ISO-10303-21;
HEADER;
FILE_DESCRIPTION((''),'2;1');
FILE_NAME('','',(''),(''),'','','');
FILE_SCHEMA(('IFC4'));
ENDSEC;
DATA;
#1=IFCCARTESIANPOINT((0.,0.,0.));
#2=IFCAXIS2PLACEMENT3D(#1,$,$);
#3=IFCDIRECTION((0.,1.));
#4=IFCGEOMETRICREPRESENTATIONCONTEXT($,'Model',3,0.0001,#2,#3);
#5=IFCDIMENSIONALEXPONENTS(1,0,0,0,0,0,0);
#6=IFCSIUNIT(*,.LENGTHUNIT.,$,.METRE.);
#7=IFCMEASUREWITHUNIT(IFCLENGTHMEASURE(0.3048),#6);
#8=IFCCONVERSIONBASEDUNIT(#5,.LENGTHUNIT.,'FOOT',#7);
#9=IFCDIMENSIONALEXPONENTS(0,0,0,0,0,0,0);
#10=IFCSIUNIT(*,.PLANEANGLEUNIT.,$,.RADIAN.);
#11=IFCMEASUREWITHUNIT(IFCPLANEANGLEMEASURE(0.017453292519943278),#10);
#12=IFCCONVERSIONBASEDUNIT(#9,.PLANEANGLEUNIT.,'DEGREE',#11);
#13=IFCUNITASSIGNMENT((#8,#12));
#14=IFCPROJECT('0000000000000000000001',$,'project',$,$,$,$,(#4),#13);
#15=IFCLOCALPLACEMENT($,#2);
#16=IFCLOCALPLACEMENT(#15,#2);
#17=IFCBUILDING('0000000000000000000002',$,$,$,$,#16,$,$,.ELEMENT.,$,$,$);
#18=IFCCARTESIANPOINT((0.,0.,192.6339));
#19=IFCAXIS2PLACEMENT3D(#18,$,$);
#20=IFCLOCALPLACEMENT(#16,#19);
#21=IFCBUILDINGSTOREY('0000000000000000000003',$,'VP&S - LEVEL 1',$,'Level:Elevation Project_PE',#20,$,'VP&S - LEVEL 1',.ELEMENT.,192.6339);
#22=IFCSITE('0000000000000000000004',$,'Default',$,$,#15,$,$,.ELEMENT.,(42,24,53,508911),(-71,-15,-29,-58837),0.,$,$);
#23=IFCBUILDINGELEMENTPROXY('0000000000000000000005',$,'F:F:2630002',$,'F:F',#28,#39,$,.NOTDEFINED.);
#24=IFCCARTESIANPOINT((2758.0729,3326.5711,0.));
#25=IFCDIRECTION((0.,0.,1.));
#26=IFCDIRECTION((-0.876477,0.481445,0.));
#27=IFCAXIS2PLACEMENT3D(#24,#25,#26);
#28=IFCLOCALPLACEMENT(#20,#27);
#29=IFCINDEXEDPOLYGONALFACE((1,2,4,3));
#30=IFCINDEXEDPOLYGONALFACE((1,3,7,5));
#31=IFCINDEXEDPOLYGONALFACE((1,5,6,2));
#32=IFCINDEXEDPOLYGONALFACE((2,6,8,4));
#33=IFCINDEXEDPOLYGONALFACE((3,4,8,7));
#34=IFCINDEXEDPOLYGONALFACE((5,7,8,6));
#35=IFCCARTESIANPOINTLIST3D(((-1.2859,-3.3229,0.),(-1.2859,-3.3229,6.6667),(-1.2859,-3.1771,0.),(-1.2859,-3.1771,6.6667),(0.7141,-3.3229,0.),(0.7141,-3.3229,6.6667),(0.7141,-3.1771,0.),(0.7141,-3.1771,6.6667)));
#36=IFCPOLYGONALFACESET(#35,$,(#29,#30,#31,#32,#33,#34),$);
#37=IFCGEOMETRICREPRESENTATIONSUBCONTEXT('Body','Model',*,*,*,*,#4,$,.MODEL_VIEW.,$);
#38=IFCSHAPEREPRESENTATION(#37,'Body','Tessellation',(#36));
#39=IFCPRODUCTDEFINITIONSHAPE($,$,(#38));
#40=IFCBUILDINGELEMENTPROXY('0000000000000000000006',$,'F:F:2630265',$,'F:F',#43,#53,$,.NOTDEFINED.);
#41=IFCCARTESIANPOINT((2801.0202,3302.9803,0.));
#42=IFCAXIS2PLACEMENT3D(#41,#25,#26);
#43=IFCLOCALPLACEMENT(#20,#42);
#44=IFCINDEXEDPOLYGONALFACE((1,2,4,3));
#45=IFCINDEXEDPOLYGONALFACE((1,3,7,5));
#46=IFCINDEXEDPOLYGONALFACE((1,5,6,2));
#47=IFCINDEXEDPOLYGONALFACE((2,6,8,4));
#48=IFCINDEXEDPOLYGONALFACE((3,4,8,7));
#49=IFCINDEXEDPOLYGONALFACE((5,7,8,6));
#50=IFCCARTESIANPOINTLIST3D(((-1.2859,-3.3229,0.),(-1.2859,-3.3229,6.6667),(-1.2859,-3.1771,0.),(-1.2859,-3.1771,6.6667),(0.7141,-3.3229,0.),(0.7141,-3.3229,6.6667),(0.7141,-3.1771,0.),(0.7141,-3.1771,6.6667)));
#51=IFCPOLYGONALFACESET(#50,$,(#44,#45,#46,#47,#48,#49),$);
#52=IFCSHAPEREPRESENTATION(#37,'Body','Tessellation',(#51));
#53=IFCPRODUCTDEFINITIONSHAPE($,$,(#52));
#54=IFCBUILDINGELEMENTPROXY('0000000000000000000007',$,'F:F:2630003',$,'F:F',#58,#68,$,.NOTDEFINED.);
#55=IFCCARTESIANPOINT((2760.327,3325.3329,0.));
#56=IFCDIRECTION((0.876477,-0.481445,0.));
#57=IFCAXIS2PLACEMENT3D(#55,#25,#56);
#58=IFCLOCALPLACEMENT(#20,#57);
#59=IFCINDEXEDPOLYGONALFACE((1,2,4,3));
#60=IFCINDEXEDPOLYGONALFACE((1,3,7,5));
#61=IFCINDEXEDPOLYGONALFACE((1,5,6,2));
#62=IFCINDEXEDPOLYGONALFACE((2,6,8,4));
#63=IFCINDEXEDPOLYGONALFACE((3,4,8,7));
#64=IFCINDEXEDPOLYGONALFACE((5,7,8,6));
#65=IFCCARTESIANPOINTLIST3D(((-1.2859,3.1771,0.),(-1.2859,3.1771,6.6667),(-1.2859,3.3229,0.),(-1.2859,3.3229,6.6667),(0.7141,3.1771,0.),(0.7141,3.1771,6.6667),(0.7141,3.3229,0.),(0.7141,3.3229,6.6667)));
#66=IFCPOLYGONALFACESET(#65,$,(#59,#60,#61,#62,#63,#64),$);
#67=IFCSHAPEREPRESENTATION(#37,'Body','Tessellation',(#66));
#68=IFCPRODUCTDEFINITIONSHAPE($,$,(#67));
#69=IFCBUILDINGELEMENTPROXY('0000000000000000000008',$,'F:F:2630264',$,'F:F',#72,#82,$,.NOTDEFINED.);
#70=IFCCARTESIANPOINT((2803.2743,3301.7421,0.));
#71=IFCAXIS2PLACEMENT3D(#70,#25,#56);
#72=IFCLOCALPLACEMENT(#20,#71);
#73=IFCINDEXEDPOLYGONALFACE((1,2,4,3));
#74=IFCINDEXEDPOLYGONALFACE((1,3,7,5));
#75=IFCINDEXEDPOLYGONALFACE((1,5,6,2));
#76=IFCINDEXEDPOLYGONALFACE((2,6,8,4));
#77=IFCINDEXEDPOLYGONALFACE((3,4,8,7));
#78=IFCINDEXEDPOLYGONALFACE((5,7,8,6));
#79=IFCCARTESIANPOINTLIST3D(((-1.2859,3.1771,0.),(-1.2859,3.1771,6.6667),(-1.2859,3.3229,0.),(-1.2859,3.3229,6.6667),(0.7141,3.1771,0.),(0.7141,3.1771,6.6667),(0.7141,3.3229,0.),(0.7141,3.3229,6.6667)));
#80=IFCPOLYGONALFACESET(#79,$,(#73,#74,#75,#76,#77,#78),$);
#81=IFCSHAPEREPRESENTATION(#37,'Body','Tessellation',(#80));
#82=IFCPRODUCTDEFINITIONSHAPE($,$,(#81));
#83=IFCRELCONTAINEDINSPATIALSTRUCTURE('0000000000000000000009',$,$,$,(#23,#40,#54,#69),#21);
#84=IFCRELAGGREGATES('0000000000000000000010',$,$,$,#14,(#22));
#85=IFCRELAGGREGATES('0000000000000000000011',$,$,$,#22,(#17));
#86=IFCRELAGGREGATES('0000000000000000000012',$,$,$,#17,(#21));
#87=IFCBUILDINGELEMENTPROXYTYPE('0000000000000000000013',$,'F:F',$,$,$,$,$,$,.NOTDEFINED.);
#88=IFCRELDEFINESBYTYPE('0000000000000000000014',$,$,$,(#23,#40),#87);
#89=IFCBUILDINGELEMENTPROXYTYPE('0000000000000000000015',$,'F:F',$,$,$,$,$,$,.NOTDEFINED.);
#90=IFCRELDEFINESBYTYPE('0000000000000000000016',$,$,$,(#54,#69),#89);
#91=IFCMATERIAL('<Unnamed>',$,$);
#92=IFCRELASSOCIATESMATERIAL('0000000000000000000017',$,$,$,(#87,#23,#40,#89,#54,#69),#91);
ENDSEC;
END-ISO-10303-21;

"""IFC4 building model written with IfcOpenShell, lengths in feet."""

from ifc_helpers import new_model, entity, si_unit, converted_unit, direction, frame, origin, place, context, subcontext, project, spatial, indexed_curve, outline, extrude, source, transform, mapped, material, type_object, type_shapes, element, save


model = new_model("IFC4")

# Units and contexts
model_context = context("Model", 3, precision=0.0001, world=origin(), true_north=direction((0.0, 1.0)))
body_context = subcontext(model_context, "Body", "Model", "MODEL_VIEW")
ifc_project = project(units=[converted_unit("LENGTHUNIT", "FOOT", entity("IfcLengthMeasure", 0.3048), si_unit("LENGTHUNIT", "METRE"), dimensions=[1, 0, 0, 0, 0, 0, 0]), converted_unit("PLANEANGLEUNIT", "DEGREE", entity("IfcPlaneAngleMeasure", 0.017453292519943278), si_unit("PLANEANGLEUNIT", "RADIAN"), dimensions=[0, 0, 0, 0, 0, 0, 0])], contexts=[model_context])

# Site, building, storey
site_placement = place(None, origin())
site = spatial("IfcSite", under=ifc_project, at=site_placement, Name="Default", CompositionType="ELEMENT", RefLatitude=(42, 24, 53, 508911), RefLongitude=(-71, -15, -29, -58837), RefElevation=0.0)
building_placement = place(site_placement, origin())
building = spatial("IfcBuilding", under=site, at=building_placement, CompositionType="ELEMENT")
storey_placement = place(building_placement, frame((0.0, 0.0, 192.6339)))
storey = spatial("IfcBuildingStorey", under=building, at=storey_placement, Name="VP&S - LEVEL 1", ObjectType="Level:Elevation Project_PE", LongName="VP&S - LEVEL 1", CompositionType="ELEMENT", Elevation=192.6339)

# Shared definitions
ifc_material = material(Name="<Unnamed>")

# Building element proxies
building_element_proxy_type_1 = type_object("IfcBuildingElementProxyType", Name="F:F", PredefinedType="NOTDEFINED", material=ifc_material)
shared_shape_1 = source(origin(), body_context, "Body", "SweptSolid", [
    extrude(outline(indexed_curve([(-1.0, -0.0729), (1.0, -0.0729), (1.0, 0.0729), (-1.0, 0.0729), (-1.0, -0.0729)], self_intersect=False)), frame((-0.2859, -3.25, 0.0), z_axis=(0.0, 0.0, 1.0), x_axis=(-1.0, 0.0, 0.0)), (0.0, 0.0, 1.0), 6.6667),
])
type_shapes(building_element_proxy_type_1, [shared_shape_1])
for number, where, z_axis, x_axis, name in (
    (1, (2758.0729, 3326.5711, 0.0), (0.0, 0.0, 1.0), (-0.876477, 0.481445, 0.0), "F:F:2630002"),
    (2, (2801.0202, 3302.9803, 0.0), (0.0, 0.0, 1.0), (-0.876477, 0.481445, 0.0), "F:F:2630265"),
):
    element("IfcBuildingElementProxy", number, at=place(storey_placement, frame(where, z_axis=z_axis, x_axis=x_axis)), inside=storey, type_object=building_element_proxy_type_1, material=ifc_material, Name=name, ObjectType="F:F", PredefinedType="NOTDEFINED", context=body_context, shape_type="MappedRepresentation", body=[
        mapped(shared_shape_1, transform((0.0, 0.0, 0.0), scale=1.0)),
    ])
building_element_proxy_type_2 = type_object("IfcBuildingElementProxyType", Name="F:F", PredefinedType="NOTDEFINED", material=ifc_material)
shared_shape_2 = source(origin(), body_context, "Body", "SweptSolid", [
    extrude(outline(indexed_curve([(-0.0729, -1.0), (0.0729, -1.0), (0.0729, 1.0), (-0.0729, 1.0), (-0.0729, -1.0)], self_intersect=False)), frame((-0.2859, 3.25, 0.0), z_axis=(0.0, 0.0, 1.0), x_axis=(0.0, 1.0, 0.0)), (0.0, 0.0, 1.0), 6.6667),
])
type_shapes(building_element_proxy_type_2, [shared_shape_2])
for number, where, z_axis, x_axis, name in (
    (3, (2760.327, 3325.3329, 0.0), (0.0, 0.0, 1.0), (0.876477, -0.481445, 0.0), "F:F:2630003"),
    (4, (2803.2743, 3301.7421, 0.0), (0.0, 0.0, 1.0), (0.876477, -0.481445, 0.0), "F:F:2630264"),
):
    element("IfcBuildingElementProxy", number, at=place(storey_placement, frame(where, z_axis=z_axis, x_axis=x_axis)), inside=storey, type_object=building_element_proxy_type_2, material=ifc_material, Name=name, ObjectType="F:F", PredefinedType="NOTDEFINED", context=body_context, shape_type="MappedRepresentation", body=[
        mapped(shared_shape_2, transform((0.0, 0.0, 0.0), scale=1.0)),
    ])

save(model, "model.ifc")
